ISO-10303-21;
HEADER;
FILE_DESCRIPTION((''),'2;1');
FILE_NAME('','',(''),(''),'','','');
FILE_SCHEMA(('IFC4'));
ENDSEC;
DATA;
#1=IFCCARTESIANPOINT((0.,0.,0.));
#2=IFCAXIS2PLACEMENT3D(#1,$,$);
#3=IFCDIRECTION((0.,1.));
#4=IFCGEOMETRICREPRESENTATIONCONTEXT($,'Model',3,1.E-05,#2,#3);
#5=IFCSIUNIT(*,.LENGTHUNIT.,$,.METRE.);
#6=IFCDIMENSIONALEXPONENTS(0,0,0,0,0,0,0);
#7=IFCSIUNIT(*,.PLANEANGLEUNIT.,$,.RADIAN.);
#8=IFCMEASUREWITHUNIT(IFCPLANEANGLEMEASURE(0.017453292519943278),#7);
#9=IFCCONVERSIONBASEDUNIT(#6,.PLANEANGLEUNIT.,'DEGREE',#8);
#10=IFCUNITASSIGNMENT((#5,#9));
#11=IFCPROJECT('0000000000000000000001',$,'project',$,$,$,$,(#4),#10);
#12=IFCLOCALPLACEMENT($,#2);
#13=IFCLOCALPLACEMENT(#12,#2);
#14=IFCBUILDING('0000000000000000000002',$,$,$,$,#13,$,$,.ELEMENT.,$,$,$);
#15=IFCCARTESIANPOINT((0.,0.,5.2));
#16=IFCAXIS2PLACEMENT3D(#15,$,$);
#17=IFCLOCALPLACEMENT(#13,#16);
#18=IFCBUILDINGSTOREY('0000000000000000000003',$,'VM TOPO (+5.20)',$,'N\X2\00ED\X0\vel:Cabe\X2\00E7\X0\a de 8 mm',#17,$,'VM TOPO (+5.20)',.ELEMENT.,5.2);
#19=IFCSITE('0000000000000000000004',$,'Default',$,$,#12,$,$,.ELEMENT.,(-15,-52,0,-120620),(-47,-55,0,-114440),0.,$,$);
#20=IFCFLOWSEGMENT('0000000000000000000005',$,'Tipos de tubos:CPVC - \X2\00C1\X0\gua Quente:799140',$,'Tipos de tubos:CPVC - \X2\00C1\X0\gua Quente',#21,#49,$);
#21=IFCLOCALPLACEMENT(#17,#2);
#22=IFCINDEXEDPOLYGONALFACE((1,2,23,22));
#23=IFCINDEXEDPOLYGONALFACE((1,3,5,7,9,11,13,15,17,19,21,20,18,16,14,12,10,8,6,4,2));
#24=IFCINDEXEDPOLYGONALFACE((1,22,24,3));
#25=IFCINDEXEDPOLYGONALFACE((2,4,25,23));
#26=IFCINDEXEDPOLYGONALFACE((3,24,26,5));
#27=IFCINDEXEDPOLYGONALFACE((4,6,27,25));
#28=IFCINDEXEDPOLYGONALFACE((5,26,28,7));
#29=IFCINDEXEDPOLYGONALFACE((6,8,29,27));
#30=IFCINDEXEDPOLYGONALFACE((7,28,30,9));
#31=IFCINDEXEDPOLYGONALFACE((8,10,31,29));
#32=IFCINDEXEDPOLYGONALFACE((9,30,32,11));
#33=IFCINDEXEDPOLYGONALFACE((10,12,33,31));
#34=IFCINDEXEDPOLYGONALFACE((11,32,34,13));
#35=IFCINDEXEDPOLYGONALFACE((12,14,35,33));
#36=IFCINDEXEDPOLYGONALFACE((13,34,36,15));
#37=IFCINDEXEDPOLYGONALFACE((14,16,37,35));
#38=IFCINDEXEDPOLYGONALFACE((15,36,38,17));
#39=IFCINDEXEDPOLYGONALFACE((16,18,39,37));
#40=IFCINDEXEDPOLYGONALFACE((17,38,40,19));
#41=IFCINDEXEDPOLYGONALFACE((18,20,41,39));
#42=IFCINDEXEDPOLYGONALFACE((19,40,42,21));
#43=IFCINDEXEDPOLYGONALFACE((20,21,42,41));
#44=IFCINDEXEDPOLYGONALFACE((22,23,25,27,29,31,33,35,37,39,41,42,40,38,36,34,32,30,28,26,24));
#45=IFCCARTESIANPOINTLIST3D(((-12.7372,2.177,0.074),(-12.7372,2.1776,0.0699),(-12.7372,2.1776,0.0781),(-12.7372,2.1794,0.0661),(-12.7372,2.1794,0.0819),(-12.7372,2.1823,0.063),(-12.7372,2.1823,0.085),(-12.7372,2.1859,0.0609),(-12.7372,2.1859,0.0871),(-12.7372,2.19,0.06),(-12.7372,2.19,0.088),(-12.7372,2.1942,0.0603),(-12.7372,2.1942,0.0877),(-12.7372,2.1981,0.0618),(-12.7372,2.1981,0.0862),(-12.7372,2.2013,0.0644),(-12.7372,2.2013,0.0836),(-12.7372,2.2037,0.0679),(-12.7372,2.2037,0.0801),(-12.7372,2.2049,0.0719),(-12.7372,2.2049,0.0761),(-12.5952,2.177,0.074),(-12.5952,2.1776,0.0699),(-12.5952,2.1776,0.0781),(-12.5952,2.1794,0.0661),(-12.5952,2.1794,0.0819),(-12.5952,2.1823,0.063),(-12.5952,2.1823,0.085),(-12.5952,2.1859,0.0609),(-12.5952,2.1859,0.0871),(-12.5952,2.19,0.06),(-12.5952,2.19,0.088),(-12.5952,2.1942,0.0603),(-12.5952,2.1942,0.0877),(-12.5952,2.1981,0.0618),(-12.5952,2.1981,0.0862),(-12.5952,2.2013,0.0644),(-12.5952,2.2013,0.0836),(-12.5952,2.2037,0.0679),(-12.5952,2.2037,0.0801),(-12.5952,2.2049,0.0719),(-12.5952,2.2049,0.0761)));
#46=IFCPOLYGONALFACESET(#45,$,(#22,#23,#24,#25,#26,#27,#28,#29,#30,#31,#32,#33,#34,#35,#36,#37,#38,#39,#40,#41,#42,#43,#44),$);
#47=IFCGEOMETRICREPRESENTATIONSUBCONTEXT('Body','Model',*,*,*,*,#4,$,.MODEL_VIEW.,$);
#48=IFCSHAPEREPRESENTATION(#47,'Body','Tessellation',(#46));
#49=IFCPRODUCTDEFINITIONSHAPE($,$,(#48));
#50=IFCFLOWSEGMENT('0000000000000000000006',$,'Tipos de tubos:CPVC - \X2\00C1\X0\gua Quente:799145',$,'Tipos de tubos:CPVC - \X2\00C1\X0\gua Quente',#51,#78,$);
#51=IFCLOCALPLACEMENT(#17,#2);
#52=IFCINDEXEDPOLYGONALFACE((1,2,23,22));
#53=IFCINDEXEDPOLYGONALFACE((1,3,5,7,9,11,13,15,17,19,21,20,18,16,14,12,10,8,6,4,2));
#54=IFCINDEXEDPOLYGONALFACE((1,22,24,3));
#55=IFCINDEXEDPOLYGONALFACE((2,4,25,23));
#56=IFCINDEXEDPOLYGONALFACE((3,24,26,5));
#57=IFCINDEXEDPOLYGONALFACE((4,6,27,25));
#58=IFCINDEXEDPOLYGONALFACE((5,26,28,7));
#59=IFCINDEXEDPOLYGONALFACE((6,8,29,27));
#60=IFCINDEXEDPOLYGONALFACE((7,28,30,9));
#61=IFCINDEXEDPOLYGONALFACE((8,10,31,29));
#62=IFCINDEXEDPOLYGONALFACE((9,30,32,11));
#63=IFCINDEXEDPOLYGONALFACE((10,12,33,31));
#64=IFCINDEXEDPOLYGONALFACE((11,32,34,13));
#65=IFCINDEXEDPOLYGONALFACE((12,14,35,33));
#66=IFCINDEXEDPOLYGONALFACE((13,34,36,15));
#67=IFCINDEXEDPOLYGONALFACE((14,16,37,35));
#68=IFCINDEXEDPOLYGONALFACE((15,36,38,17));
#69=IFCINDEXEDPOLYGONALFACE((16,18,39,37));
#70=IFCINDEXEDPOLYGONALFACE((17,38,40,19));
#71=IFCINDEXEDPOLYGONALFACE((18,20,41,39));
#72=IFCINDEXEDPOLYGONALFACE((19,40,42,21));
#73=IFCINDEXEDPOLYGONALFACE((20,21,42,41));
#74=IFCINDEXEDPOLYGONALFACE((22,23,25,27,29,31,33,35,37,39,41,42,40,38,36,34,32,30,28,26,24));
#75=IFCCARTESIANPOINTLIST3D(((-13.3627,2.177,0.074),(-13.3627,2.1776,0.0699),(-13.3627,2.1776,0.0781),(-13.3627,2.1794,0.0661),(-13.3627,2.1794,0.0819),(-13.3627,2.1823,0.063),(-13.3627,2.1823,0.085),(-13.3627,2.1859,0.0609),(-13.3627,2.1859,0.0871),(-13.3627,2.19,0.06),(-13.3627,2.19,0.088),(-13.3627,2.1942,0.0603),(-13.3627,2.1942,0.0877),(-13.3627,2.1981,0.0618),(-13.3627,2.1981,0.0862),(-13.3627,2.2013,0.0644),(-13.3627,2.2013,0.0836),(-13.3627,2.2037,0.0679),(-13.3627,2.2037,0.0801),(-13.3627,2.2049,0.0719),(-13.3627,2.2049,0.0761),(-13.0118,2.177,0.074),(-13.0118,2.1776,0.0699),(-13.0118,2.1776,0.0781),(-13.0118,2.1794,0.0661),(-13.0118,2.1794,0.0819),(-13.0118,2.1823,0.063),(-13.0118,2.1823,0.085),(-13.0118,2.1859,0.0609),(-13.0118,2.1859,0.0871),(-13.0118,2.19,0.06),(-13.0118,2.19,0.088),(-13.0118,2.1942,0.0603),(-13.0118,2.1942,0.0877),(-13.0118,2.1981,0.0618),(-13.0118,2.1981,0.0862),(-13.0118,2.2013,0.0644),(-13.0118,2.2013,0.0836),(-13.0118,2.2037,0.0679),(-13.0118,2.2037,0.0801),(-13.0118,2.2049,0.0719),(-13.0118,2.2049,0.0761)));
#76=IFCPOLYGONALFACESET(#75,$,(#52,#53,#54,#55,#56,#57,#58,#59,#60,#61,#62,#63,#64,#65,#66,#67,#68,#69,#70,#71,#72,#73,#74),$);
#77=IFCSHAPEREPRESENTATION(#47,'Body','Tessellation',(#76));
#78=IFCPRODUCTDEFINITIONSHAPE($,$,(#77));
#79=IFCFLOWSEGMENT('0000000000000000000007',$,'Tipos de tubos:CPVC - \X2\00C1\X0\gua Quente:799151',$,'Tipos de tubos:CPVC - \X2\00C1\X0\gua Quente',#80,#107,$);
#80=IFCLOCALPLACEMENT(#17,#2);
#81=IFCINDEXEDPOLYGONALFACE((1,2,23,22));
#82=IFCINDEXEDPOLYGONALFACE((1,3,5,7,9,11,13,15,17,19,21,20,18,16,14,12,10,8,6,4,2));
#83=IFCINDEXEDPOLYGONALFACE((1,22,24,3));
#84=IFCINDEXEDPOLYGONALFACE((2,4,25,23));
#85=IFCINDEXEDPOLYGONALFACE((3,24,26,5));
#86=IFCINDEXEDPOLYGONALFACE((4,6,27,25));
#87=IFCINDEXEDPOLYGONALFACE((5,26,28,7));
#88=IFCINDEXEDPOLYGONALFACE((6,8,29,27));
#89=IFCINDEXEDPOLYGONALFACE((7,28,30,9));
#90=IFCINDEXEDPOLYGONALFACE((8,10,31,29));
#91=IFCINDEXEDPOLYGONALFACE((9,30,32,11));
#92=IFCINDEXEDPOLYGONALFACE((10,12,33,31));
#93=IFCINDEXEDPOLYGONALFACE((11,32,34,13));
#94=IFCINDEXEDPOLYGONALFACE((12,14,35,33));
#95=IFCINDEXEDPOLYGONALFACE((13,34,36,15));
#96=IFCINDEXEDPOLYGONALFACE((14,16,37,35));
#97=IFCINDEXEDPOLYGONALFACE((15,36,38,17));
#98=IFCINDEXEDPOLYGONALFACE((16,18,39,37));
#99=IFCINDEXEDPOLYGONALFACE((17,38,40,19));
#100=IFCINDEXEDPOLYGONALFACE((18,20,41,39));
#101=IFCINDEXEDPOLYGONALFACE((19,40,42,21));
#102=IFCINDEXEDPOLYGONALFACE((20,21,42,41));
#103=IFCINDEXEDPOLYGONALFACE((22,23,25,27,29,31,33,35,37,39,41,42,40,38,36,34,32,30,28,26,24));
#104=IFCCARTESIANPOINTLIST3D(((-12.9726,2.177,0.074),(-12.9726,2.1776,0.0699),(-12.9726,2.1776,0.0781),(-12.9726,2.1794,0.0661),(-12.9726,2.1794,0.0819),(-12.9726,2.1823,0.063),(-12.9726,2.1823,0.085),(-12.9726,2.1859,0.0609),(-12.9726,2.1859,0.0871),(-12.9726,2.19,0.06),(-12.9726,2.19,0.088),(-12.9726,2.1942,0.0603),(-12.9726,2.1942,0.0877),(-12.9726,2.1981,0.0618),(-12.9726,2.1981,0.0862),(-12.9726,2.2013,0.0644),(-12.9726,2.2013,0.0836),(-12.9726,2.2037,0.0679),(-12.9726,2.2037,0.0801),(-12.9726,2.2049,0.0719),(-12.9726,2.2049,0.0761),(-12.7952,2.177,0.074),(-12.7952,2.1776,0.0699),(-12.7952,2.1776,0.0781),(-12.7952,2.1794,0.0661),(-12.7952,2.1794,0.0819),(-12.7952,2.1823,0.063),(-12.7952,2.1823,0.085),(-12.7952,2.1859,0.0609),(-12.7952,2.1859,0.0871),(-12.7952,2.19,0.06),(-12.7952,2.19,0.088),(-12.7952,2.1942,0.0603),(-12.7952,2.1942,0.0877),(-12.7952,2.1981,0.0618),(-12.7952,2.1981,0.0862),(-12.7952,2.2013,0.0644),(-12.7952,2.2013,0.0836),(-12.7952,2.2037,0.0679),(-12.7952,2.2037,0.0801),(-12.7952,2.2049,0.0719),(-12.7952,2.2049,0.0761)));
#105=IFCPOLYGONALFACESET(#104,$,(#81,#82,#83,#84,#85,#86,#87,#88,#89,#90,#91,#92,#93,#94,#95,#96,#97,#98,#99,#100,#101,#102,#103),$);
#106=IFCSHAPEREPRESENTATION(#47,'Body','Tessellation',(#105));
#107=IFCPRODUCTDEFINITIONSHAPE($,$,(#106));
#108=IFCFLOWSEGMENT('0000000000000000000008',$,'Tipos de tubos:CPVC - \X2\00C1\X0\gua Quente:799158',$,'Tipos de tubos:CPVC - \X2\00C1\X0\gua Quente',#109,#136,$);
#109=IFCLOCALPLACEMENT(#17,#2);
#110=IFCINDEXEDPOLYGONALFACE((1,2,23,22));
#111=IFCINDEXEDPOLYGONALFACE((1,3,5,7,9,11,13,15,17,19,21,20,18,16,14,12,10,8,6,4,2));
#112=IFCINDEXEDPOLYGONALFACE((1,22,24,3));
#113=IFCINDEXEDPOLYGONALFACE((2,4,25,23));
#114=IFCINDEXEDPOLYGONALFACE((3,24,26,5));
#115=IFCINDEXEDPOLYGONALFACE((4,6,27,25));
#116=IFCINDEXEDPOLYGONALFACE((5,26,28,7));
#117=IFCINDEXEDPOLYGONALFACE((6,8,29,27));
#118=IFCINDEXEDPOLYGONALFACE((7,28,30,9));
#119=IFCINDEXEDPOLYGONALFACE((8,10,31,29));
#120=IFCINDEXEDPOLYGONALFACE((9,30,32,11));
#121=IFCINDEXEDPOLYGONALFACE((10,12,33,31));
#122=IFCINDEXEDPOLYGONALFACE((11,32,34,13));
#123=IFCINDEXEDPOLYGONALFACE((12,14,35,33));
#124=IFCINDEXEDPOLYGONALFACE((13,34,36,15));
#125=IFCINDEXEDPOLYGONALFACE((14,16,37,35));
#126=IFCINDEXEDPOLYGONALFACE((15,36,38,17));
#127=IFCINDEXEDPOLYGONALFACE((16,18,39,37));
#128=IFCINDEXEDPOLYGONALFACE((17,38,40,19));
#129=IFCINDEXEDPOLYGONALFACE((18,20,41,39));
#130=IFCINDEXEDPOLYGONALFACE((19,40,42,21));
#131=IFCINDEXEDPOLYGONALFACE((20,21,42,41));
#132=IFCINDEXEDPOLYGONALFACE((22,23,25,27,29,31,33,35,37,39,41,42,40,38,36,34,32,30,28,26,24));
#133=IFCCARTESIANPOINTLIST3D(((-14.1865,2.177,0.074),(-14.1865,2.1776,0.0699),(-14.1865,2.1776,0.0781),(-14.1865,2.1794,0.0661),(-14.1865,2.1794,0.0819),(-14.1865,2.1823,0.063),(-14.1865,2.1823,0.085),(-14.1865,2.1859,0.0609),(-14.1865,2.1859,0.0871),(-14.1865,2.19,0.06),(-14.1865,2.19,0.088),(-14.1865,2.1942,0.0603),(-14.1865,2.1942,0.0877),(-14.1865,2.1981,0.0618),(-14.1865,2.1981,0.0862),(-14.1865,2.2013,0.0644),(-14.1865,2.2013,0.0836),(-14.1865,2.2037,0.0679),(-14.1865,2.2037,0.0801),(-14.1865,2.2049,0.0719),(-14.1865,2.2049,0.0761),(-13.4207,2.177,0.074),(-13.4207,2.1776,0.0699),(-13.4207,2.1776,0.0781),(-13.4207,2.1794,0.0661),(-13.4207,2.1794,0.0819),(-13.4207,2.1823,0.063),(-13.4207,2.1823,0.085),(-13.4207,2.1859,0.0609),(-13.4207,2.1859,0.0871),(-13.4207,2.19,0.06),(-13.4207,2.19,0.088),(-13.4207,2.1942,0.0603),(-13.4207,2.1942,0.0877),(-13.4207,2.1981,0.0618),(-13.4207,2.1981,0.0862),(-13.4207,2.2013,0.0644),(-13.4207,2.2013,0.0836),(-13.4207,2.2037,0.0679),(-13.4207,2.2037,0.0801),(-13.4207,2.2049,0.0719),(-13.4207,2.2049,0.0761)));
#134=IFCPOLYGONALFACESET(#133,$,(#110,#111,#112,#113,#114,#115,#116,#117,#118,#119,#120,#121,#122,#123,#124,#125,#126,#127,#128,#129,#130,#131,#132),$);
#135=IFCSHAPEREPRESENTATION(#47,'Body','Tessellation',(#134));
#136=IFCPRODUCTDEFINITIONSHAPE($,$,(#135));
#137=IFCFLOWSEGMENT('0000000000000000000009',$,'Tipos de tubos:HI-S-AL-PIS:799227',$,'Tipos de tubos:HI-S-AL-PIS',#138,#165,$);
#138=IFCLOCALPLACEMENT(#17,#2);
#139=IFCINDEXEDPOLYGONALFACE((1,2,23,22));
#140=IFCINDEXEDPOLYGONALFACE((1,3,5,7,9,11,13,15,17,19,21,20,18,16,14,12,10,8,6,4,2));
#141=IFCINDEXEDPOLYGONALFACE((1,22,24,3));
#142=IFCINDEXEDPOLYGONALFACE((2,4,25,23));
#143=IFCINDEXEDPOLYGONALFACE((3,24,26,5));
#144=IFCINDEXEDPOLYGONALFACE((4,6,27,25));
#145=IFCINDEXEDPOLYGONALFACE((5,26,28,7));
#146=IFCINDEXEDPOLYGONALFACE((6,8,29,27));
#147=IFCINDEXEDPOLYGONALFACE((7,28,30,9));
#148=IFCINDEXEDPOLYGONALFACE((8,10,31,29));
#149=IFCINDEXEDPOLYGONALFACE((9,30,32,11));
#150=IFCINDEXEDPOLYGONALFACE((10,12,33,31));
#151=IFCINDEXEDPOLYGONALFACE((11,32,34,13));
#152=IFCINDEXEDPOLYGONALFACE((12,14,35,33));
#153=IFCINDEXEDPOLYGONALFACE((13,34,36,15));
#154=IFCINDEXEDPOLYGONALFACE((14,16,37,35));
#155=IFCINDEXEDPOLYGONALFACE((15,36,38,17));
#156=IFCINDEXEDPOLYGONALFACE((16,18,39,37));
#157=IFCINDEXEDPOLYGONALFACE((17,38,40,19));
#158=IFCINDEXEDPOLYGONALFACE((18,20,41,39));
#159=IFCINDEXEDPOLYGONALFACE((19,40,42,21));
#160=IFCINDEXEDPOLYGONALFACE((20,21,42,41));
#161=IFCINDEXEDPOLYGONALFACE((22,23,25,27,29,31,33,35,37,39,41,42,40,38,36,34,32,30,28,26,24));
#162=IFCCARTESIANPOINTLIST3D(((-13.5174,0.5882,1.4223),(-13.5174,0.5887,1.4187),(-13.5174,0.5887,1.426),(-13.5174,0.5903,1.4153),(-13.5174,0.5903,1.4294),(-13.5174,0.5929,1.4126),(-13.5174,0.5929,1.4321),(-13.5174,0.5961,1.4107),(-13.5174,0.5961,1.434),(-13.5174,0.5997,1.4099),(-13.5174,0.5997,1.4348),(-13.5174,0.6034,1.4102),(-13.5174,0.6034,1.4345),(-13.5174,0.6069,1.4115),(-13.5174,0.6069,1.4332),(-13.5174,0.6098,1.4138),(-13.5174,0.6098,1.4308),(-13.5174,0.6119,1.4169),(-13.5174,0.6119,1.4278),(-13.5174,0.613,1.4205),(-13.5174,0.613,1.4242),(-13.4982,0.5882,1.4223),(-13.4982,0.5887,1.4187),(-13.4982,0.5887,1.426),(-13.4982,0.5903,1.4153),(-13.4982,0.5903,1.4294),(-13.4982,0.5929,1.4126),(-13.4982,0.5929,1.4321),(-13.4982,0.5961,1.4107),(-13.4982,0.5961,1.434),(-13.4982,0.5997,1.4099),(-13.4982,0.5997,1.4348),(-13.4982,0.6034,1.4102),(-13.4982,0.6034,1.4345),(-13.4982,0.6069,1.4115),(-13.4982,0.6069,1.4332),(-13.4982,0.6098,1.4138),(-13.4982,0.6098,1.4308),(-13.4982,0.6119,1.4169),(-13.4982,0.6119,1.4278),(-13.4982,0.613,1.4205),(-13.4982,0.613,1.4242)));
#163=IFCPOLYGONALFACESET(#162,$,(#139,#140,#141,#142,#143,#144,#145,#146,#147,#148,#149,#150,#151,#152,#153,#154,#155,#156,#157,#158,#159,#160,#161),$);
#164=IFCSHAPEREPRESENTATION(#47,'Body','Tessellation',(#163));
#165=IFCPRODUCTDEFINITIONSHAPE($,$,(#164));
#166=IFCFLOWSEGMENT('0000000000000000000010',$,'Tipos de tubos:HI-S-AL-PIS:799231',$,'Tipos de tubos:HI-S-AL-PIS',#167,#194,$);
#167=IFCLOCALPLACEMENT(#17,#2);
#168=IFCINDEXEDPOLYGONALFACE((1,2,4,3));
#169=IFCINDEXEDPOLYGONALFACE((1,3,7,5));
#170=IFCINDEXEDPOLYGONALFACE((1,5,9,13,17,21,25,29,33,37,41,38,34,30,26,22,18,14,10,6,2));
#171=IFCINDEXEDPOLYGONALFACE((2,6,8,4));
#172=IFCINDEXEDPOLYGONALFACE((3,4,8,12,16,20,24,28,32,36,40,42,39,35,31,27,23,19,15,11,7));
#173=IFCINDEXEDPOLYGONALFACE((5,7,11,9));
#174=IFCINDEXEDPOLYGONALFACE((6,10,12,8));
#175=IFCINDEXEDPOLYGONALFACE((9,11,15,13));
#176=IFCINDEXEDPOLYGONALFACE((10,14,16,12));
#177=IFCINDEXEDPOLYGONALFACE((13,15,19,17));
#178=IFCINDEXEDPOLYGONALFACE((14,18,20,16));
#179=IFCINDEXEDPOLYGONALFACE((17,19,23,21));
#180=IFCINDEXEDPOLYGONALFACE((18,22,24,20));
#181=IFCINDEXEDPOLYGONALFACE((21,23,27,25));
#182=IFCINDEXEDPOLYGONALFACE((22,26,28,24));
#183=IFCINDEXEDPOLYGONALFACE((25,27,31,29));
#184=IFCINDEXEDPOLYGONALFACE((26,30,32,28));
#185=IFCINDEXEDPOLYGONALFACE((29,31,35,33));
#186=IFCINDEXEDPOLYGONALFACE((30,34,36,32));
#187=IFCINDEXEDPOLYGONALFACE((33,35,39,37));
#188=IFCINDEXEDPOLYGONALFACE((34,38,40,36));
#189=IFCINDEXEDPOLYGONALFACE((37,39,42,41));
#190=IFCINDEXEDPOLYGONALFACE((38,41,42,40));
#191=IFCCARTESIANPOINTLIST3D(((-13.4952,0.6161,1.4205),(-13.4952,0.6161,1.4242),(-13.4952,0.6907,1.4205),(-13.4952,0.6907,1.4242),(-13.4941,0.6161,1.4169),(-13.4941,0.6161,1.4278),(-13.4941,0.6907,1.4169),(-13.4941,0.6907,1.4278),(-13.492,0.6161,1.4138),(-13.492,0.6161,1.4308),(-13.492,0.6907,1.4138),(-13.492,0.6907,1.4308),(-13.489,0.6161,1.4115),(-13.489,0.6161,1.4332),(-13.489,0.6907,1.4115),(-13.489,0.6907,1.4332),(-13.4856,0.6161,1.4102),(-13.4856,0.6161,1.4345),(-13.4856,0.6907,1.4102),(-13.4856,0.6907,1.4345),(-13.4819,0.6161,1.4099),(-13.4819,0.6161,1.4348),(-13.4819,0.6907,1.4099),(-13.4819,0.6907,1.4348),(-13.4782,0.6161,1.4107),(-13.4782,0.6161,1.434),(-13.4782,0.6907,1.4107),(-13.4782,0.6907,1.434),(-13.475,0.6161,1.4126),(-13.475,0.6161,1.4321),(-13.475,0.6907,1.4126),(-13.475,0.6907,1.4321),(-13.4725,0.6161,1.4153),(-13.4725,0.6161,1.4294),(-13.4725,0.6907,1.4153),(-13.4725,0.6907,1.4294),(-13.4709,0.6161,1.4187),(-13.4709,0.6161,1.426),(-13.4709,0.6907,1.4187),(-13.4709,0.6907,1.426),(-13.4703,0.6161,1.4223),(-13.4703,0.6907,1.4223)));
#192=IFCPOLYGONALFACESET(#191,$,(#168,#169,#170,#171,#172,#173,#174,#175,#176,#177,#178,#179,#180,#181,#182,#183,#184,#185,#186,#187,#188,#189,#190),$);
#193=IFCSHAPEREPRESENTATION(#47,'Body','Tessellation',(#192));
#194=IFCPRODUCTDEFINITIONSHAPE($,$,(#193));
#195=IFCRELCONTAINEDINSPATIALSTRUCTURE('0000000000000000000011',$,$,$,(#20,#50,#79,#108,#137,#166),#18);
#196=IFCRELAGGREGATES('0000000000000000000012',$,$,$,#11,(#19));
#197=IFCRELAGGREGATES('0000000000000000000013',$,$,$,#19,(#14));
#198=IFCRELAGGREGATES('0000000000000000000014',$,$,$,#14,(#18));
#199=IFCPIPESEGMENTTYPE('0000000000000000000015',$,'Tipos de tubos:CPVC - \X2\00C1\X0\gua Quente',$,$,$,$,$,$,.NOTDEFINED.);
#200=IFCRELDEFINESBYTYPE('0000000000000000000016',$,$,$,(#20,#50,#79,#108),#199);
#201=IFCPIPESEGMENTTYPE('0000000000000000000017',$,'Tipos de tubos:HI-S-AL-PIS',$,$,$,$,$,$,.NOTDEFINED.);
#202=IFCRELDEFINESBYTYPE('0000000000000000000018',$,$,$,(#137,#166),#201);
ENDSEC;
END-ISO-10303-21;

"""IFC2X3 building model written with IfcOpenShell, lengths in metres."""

from ifc_helpers import new_model, entity, si_unit, converted_unit, direction, frame, frame_2d, origin, origin_2d_with_axis, place, context, subcontext, project, spatial, circle, extrude, type_object, element, save


model = new_model("IFC2X3")

# Units and contexts
model_context = context("Model", 3, precision=1e-05, world=origin(), true_north=direction((0.0, 1.0)))
body_context = subcontext(model_context, "Body", "Model", "MODEL_VIEW")
ifc_project = project(units=[si_unit("LENGTHUNIT", "METRE"), converted_unit("PLANEANGLEUNIT", "DEGREE", entity("IfcPlaneAngleMeasure", 0.017453292519943278), si_unit("PLANEANGLEUNIT", "RADIAN"), dimensions=[0, 0, 0, 0, 0, 0, 0])], contexts=[model_context])

# Site, building, storey
site_placement = place(None, origin())
site = spatial("IfcSite", under=ifc_project, at=site_placement, Name="Default", CompositionType="ELEMENT", RefLatitude=(-15, -52, 0, -120620), RefLongitude=(-47, -55, 0, -114440), RefElevation=0.0)
building_placement = place(site_placement, origin())
building = spatial("IfcBuilding", under=site, at=building_placement, CompositionType="ELEMENT")
storey_placement = place(building_placement, frame((0.0, 0.0, 5.2)))
storey = spatial("IfcBuildingStorey", under=building, at=storey_placement, Name="VM TOPO (+5.20)", ObjectType="Nível:Cabeça de 8 mm", LongName="VM TOPO (+5.20)", CompositionType="ELEMENT", Elevation=5.2)

# Flow segments
pipe_segment_type_1 = type_object("IfcPipeSegmentType", Name="Tipos de tubos:CPVC - Água Quente", PredefinedType="NOTDEFINED")
flow_segment_1_placement = place(storey_placement, origin())
element("IfcFlowSegment", 1, at=flow_segment_1_placement, inside=storey, type_object=pipe_segment_type_1, Name="Tipos de tubos:CPVC - Água Quente:799140", ObjectType="Tipos de tubos:CPVC - Água Quente", context=body_context, shape_type="SweptSolid", body=[
    extrude(circle(Radius=0.0141, at=origin_2d_with_axis()), frame((-12.7372, 2.191, 0.074), z_axis=(1.0, 0.0, 0.0), x_axis=(0.0, -1.0, 0.0)), (0.0, 0.0, 1.0), 0.142),
])
flow_segment_2_placement = place(storey_placement, origin())
element("IfcFlowSegment", 2, at=flow_segment_2_placement, inside=storey, type_object=pipe_segment_type_1, Name="Tipos de tubos:CPVC - Água Quente:799145", ObjectType="Tipos de tubos:CPVC - Água Quente", context=body_context, shape_type="SweptSolid", body=[
    extrude(circle(Radius=0.0141, at=origin_2d_with_axis()), frame((-13.3627, 2.191, 0.074), z_axis=(1.0, 0.0, 0.0), x_axis=(0.0, -1.0, 0.0)), (0.0, 0.0, 1.0), 0.3509),
])
flow_segment_3_placement = place(storey_placement, origin())
element("IfcFlowSegment", 3, at=flow_segment_3_placement, inside=storey, type_object=pipe_segment_type_1, Name="Tipos de tubos:CPVC - Água Quente:799151", ObjectType="Tipos de tubos:CPVC - Água Quente", context=body_context, shape_type="SweptSolid", body=[
    extrude(circle(Radius=0.0141, at=origin_2d_with_axis()), frame((-12.9726, 2.191, 0.074), z_axis=(1.0, 0.0, 0.0), x_axis=(0.0, -1.0, 0.0)), (0.0, 0.0, 1.0), 0.1774),
])
flow_segment_4_placement = place(storey_placement, origin())
element("IfcFlowSegment", 4, at=flow_segment_4_placement, inside=storey, type_object=pipe_segment_type_1, Name="Tipos de tubos:CPVC - Água Quente:799158", ObjectType="Tipos de tubos:CPVC - Água Quente", context=body_context, shape_type="SweptSolid", body=[
    extrude(circle(Radius=0.0141, at=origin_2d_with_axis()), frame((-14.1865, 2.191, 0.074), z_axis=(1.0, 0.0, 0.0), x_axis=(0.0, -1.0, 0.0)), (0.0, 0.0, 1.0), 0.7658),
])
pipe_segment_type_2 = type_object("IfcPipeSegmentType", Name="Tipos de tubos:HI-S-AL-PIS", PredefinedType="NOTDEFINED")
flow_segment_5_placement = place(storey_placement, origin())
element("IfcFlowSegment", 5, at=flow_segment_5_placement, inside=storey, type_object=pipe_segment_type_2, Name="Tipos de tubos:HI-S-AL-PIS:799227", ObjectType="Tipos de tubos:HI-S-AL-PIS", context=body_context, shape_type="SweptSolid", body=[
    extrude(circle(Radius=0.0125, at=frame_2d((0.0, 0.0), x_axis=(1.0, 0.0))), frame((-13.5174, 0.6007, 1.4223), z_axis=(1.0, 0.0, 0.0), x_axis=(0.0, -1.0, 0.0)), (0.0, 0.0, 1.0), 0.0192),
])
flow_segment_6_placement = place(storey_placement, origin())
element("IfcFlowSegment", 6, at=flow_segment_6_placement, inside=storey, type_object=pipe_segment_type_2, Name="Tipos de tubos:HI-S-AL-PIS:799231", ObjectType="Tipos de tubos:HI-S-AL-PIS", context=body_context, shape_type="SweptSolid", body=[
    extrude(circle(Radius=0.0125, at=origin_2d_with_axis()), frame((-13.4828, 0.6161, 1.4223), z_axis=(0.0, 1.0, 0.0), x_axis=(1.0, 0.0, 0.0)), (0.0, 0.0, 1.0), 0.0746),
])

save(model, "model.ifc")
